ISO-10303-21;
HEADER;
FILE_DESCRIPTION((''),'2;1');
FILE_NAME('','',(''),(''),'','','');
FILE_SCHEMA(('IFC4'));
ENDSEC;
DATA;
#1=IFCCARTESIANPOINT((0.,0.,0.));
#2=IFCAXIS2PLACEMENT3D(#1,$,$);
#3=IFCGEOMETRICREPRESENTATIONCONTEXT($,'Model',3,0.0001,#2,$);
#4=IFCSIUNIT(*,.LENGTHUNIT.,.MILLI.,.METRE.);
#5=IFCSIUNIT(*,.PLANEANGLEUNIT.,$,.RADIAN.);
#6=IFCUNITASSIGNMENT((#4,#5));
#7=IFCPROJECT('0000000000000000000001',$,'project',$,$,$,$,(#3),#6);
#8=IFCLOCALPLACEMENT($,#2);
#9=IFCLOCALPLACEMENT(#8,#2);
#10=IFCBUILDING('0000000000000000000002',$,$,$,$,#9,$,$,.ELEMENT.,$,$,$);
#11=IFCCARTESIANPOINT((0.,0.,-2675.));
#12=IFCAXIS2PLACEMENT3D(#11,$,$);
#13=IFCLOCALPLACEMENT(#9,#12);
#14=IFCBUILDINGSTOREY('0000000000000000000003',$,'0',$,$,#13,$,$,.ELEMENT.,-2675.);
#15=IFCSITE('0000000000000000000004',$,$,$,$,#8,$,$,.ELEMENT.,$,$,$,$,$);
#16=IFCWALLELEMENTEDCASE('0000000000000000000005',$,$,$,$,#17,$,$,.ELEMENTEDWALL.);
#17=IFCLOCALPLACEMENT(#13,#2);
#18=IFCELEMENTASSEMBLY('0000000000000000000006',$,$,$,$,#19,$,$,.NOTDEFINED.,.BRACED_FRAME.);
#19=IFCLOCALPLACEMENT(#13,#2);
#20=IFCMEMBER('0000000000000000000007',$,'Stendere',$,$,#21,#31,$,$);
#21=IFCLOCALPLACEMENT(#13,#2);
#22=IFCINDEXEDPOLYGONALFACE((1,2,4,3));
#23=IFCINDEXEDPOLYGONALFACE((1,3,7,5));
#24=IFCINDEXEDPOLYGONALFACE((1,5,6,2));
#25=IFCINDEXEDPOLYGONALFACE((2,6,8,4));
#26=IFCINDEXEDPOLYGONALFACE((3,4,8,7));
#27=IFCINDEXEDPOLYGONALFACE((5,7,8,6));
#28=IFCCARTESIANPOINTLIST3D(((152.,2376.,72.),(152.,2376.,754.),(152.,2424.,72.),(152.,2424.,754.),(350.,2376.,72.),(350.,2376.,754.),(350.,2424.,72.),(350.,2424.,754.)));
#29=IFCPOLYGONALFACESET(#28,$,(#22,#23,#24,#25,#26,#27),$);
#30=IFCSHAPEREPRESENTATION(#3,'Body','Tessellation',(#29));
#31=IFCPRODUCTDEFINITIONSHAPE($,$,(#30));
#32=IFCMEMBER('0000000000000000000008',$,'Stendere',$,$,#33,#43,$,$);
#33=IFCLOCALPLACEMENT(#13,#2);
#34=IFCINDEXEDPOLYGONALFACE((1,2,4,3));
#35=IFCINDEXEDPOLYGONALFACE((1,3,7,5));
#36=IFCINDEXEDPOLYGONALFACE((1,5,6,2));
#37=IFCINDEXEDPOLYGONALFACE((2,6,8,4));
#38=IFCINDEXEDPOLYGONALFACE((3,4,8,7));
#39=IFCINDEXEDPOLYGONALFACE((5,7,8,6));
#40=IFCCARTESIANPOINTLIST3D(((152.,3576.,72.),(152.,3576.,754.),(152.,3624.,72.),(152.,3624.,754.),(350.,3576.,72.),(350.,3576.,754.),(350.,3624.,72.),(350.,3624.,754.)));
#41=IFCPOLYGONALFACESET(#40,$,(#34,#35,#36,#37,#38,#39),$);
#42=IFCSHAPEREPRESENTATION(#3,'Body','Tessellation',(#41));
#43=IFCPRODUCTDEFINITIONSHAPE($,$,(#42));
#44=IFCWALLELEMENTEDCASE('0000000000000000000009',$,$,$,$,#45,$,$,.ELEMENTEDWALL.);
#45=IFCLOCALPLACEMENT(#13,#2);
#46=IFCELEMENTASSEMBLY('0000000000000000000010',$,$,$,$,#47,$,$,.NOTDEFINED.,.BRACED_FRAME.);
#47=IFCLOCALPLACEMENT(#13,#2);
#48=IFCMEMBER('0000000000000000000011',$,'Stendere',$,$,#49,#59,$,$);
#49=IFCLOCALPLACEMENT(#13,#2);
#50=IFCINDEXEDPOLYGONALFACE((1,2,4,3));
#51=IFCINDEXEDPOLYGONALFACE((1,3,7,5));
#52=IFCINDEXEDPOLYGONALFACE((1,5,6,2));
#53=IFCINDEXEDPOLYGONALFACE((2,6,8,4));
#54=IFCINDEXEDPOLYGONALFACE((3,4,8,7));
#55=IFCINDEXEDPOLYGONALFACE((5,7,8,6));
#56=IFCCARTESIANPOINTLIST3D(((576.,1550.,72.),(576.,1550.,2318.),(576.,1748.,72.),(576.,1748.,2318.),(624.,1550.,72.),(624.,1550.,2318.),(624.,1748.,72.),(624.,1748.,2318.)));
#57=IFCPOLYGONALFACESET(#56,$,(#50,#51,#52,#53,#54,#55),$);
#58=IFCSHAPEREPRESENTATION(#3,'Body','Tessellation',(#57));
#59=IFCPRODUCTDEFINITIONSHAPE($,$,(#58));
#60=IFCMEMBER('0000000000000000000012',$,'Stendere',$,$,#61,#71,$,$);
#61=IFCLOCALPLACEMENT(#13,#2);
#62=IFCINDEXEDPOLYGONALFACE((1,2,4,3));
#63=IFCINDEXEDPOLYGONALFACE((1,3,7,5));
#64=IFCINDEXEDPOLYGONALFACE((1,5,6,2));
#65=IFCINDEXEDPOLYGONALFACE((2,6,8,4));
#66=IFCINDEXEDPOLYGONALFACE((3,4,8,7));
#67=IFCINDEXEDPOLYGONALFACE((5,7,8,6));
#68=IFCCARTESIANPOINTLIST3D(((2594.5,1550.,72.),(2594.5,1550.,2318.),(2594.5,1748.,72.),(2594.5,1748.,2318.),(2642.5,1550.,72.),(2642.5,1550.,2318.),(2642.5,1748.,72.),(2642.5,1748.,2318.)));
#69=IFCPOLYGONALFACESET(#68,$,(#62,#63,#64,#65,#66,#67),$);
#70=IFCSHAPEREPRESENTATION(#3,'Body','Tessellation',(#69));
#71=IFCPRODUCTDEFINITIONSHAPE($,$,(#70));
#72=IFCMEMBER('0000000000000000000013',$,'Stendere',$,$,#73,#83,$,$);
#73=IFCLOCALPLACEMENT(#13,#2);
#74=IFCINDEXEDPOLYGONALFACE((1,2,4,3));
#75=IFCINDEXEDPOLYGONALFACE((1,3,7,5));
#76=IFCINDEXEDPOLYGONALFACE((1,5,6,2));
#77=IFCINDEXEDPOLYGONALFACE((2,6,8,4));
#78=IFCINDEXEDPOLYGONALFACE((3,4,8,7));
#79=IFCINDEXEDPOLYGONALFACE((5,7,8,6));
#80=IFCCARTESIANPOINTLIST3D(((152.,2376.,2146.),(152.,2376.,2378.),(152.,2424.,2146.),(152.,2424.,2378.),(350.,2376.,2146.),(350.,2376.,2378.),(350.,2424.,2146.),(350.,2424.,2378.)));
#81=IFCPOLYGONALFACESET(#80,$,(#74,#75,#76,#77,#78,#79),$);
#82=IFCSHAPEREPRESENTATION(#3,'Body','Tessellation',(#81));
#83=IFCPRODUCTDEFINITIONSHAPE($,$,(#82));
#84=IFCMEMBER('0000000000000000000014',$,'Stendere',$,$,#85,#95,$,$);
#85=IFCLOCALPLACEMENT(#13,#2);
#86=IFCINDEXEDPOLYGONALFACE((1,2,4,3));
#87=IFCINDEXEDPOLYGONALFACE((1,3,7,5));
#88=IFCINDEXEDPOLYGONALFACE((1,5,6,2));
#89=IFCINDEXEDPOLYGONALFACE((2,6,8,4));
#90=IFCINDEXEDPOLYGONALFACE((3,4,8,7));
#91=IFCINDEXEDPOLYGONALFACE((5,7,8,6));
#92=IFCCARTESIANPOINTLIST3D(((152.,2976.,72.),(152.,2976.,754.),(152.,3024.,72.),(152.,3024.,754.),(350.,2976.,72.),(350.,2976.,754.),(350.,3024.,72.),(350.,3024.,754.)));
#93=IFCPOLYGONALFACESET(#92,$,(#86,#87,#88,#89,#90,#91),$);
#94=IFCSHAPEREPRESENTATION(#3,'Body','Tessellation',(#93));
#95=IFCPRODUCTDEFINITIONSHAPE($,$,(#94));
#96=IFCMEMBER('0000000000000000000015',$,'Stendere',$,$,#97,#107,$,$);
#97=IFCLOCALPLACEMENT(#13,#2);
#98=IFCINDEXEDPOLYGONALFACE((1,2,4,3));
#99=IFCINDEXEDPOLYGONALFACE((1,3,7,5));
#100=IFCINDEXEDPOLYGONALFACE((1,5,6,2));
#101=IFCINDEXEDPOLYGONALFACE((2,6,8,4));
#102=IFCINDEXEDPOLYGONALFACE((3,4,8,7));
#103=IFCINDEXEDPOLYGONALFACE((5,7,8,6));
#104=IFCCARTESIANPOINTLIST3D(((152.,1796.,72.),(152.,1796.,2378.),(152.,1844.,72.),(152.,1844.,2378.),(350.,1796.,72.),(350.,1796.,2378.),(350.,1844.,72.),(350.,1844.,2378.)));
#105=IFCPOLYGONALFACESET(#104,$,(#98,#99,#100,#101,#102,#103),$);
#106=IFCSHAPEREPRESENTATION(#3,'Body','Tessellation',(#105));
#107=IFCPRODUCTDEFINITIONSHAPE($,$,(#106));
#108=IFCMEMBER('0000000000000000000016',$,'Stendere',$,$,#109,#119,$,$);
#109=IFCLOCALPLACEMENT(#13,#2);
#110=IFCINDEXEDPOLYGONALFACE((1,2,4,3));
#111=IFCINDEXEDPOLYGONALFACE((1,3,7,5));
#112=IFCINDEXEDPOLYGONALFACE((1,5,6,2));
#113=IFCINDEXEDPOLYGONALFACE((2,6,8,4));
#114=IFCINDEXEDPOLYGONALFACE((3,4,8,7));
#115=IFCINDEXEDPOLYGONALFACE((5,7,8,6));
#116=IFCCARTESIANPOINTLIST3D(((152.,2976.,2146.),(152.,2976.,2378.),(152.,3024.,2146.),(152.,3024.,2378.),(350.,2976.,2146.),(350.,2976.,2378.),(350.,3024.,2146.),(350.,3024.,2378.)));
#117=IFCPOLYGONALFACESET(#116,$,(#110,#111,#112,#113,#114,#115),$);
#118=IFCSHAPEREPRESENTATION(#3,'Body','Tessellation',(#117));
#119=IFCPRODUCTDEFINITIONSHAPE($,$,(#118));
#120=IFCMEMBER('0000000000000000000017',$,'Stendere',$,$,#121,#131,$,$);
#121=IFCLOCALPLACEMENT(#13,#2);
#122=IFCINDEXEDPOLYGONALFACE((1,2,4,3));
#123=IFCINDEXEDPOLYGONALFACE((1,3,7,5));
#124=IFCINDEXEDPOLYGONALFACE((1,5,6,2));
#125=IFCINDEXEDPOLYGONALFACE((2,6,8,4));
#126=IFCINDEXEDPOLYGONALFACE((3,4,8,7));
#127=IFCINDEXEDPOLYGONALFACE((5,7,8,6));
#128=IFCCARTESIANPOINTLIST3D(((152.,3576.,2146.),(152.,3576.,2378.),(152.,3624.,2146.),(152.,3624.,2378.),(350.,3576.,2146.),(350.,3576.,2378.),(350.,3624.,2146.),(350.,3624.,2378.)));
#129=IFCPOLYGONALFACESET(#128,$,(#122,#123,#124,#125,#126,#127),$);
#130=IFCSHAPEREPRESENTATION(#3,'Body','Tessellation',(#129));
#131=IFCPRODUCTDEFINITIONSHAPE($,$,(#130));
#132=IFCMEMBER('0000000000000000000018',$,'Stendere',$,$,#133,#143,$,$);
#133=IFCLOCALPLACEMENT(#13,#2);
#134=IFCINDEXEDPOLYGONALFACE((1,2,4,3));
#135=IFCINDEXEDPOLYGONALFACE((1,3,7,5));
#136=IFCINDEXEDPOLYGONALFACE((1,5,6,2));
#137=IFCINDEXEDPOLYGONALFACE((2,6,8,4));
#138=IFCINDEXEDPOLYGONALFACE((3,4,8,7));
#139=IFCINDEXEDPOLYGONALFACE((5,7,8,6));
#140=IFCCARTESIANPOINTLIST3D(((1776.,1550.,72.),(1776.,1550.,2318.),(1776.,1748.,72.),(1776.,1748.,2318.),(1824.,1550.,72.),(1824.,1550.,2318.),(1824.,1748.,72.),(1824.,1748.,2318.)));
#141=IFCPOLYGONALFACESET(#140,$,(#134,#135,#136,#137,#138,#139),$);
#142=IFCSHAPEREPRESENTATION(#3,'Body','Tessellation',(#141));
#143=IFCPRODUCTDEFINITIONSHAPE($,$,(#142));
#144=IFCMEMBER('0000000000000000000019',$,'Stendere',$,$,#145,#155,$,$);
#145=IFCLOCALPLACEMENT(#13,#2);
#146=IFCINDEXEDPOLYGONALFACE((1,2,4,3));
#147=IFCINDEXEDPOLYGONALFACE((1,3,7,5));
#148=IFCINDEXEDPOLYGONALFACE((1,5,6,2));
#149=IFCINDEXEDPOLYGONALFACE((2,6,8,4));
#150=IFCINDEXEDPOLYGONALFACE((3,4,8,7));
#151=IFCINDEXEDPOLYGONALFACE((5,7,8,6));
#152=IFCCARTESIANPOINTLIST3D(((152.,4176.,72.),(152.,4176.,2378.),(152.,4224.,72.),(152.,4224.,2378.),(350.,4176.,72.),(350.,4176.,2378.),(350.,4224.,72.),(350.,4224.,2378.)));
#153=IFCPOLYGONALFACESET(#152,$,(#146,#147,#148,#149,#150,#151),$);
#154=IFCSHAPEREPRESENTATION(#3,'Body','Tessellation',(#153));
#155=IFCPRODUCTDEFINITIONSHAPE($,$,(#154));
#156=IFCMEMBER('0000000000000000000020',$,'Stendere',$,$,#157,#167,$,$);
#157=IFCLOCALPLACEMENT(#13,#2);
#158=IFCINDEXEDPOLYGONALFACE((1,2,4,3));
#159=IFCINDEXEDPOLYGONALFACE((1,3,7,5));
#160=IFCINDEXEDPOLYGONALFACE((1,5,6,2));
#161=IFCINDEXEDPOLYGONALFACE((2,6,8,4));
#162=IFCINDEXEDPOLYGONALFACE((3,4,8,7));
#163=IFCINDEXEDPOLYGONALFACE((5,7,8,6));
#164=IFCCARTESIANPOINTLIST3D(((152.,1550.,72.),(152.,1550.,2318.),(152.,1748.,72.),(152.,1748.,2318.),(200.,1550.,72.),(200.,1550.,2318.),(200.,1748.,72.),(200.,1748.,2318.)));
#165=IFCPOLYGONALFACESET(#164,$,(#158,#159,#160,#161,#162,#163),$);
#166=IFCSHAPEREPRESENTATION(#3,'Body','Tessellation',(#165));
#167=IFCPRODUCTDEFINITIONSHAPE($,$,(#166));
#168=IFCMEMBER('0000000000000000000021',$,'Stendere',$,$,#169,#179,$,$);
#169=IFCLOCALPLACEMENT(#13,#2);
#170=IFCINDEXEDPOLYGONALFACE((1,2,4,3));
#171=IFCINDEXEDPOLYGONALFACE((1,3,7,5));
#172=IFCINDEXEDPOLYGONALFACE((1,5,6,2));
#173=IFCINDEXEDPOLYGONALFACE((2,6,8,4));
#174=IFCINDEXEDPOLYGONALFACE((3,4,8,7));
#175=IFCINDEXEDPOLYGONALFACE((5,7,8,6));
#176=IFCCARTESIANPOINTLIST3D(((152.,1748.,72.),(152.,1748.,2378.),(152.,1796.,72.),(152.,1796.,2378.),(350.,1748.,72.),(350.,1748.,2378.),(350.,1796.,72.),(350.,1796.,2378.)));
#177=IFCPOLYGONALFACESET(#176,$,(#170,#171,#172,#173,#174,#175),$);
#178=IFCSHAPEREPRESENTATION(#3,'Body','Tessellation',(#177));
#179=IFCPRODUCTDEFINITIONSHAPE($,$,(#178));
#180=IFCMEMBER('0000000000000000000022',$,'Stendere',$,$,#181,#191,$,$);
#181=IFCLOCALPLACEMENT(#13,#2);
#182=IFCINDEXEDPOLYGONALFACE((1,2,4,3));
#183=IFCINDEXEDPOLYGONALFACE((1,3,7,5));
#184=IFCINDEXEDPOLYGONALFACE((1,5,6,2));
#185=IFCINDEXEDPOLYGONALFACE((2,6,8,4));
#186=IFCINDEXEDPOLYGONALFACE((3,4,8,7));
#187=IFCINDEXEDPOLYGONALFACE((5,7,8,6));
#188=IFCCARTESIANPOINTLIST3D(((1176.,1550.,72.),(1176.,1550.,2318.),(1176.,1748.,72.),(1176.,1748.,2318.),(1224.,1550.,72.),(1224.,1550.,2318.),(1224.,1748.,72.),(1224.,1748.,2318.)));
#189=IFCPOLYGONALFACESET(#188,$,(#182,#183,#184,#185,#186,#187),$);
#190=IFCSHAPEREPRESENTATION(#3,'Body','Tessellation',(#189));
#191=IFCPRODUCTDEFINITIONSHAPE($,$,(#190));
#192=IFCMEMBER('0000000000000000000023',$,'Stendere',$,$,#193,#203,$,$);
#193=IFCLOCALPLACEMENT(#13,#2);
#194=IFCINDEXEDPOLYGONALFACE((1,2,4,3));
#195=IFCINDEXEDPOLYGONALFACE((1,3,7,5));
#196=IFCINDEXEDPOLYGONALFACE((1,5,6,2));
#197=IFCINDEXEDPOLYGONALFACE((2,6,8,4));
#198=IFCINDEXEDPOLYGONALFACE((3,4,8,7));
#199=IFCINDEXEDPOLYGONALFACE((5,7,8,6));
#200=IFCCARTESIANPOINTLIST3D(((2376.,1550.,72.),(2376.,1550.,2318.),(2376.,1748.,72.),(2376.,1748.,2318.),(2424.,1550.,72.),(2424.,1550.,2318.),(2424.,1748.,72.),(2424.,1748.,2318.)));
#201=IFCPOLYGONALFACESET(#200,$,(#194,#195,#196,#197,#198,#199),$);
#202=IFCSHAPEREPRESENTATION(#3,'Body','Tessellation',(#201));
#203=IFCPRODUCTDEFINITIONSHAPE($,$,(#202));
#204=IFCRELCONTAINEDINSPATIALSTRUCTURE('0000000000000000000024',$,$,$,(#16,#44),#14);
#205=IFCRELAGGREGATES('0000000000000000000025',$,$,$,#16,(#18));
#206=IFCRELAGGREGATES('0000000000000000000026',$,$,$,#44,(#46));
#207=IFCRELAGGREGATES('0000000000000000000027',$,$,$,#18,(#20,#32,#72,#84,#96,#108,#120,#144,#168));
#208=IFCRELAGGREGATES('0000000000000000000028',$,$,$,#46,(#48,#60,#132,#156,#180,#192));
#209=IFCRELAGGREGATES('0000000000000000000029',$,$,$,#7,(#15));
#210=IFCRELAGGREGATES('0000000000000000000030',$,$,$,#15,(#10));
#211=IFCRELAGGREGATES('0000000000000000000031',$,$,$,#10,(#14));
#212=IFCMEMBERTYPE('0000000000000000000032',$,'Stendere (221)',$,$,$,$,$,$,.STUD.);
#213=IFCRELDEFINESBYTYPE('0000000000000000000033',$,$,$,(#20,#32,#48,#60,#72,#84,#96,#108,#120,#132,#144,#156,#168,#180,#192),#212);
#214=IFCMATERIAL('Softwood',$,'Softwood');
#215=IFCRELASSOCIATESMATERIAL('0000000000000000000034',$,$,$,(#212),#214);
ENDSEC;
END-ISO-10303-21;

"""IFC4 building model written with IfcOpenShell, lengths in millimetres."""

from ifc_helpers import new_model, si_unit, frame, origin, place, context, project, spatial, rectangle, extrude, material, material_profile, profile_set, type_object, element, aggregate, save


model = new_model("IFC4")

# Units and contexts
model_context = context("Model", 3, precision=0.0001, world=origin())
ifc_project = project(units=[si_unit("LENGTHUNIT", "METRE", prefix="MILLI"), si_unit("PLANEANGLEUNIT", "RADIAN")], contexts=[model_context])

# Site, building, storey
site_placement = place(None, origin())
site = spatial("IfcSite", under=ifc_project, at=site_placement, CompositionType="ELEMENT")
building_placement = place(site_placement, origin())
building = spatial("IfcBuilding", under=site, at=building_placement, CompositionType="ELEMENT")
storey_placement = place(building_placement, frame((0.0, 0.0, -2675.0)))
storey = spatial("IfcBuildingStorey", under=building, at=storey_placement, Name="0", CompositionType="ELEMENT", Elevation=-2675.0)

# Walls, element assemblies, members
wall_1_placement = place(storey_placement, frame((350.0, 6150.0, 0.0), z_axis=(-1.0, 0.0, 0.0), x_axis=(0.0, -1.0, 0.0)))
wall_1 = element("IfcWallElementedCase", 1, at=wall_1_placement, inside=storey, PredefinedType="ELEMENTEDWALL")
assembly_1_placement = place(wall_1_placement, origin())
assembly_1 = element("IfcElementAssembly", 2, at=assembly_1_placement, AssemblyPlace="NOTDEFINED", PredefinedType="BRACED_FRAME")
aggregate(wall_1, [assembly_1])
ifc_material_1 = material(Name="Softwood", Category="Softwood")
ifc_material_profile_1 = material_profile(ifc_material_1, rectangle(XDim=48.0, YDim=198.0), Name="Stendere (221)")
ifc_profile_set_1 = profile_set([ifc_material_profile_1])
member_type_1 = type_object("IfcMemberType", Name="Stendere (221)", PredefinedType="STUD", material=ifc_profile_set_1)
member_1_placement = place(assembly_1_placement, frame((3750.0, 72.0, 0.0), z_axis=(0.0, 1.0, 0.0), x_axis=(-1.0, 0.0, 0.0)))
member_1 = element("IfcMember", 3, at=member_1_placement, type_object=member_type_1, Name="Stendere", context=model_context, shape_type="SweptSolid", body=[
    extrude(rectangle(XDim=48.0, YDim=198.0), frame((0.0, 99.0, 0.0)), (0.0, 0.0, 1.0), 682.0),
])
member_2_placement = place(assembly_1_placement, frame((2550.0, 72.0, 0.0), z_axis=(0.0, 1.0, 0.0), x_axis=(-1.0, 0.0, 0.0)))
member_2 = element("IfcMember", 4, at=member_2_placement, type_object=member_type_1, Name="Stendere", context=model_context, shape_type="SweptSolid", body=[
    extrude(rectangle(XDim=48.0, YDim=198.0), frame((0.0, 99.0, 0.0)), (0.0, 0.0, 1.0), 682.0),
])
wall_2_placement = place(storey_placement, frame((350.0, 1748.0, 0.0), z_axis=(0.0, -1.0, 0.0)))
wall_2 = element("IfcWallElementedCase", 5, at=wall_2_placement, inside=storey, PredefinedType="ELEMENTEDWALL")
assembly_2_placement = place(wall_2_placement, origin())
assembly_2 = element("IfcElementAssembly", 6, at=assembly_2_placement, AssemblyPlace="NOTDEFINED", PredefinedType="BRACED_FRAME")
aggregate(wall_2, [assembly_2])
member_3_placement = place(assembly_2_placement, frame((250.0, 72.0, 0.0), z_axis=(0.0, 1.0, 0.0), x_axis=(-1.0, 0.0, 0.0)))
member_3 = element("IfcMember", 7, at=member_3_placement, type_object=member_type_1, Name="Stendere", context=model_context, shape_type="SweptSolid", body=[
    extrude(rectangle(XDim=48.0, YDim=198.0), frame((0.0, 99.0, 0.0)), (0.0, 0.0, 1.0), 2246.0),
])
member_4_placement = place(assembly_2_placement, frame((2268.5, 72.0, 0.0), z_axis=(0.0, 1.0, 0.0), x_axis=(-1.0, 0.0, 0.0)))
member_4 = element("IfcMember", 8, at=member_4_placement, type_object=member_type_1, Name="Stendere", context=model_context, shape_type="SweptSolid", body=[
    extrude(rectangle(XDim=48.0, YDim=198.0), frame((0.0, 99.0, 0.0)), (0.0, 0.0, 1.0), 2246.0),
])

# Members
member_5_placement = place(assembly_1_placement, frame((3750.0, 2146.0, 0.0), z_axis=(0.0, 1.0, 0.0), x_axis=(-1.0, 0.0, 0.0)))
member_5 = element("IfcMember", 9, at=member_5_placement, type_object=member_type_1, Name="Stendere", context=model_context, shape_type="SweptSolid", body=[
    extrude(rectangle(XDim=48.0, YDim=198.0), frame((0.0, 99.0, 0.0)), (0.0, 0.0, 1.0), 232.0),
])
member_6_placement = place(assembly_1_placement, frame((3150.0, 72.0, 0.0), z_axis=(0.0, 1.0, 0.0), x_axis=(-1.0, 0.0, 0.0)))
member_6 = element("IfcMember", 10, at=member_6_placement, type_object=member_type_1, Name="Stendere", context=model_context, shape_type="SweptSolid", body=[
    extrude(rectangle(XDim=48.0, YDim=198.0), frame((0.0, 99.0, 0.0)), (0.0, 0.0, 1.0), 682.0),
])
member_7_placement = place(assembly_1_placement, frame((4330.0, 72.0, 0.0), z_axis=(0.0, 1.0, 0.0), x_axis=(-1.0, 0.0, 0.0)))
member_7 = element("IfcMember", 11, at=member_7_placement, type_object=member_type_1, Name="Stendere", context=model_context, shape_type="SweptSolid", body=[
    extrude(rectangle(XDim=48.0, YDim=198.0), frame((0.0, 99.0, 0.0)), (0.0, 0.0, 1.0), 2306.0),
])
member_8_placement = place(assembly_1_placement, frame((3150.0, 2146.0, 0.0), z_axis=(0.0, 1.0, 0.0), x_axis=(-1.0, 0.0, 0.0)))
member_8 = element("IfcMember", 12, at=member_8_placement, type_object=member_type_1, Name="Stendere", context=model_context, shape_type="SweptSolid", body=[
    extrude(rectangle(XDim=48.0, YDim=198.0), frame((0.0, 99.0, 0.0)), (0.0, 0.0, 1.0), 232.0),
])
member_9_placement = place(assembly_1_placement, frame((2550.0, 2146.0, 0.0), z_axis=(0.0, 1.0, 0.0), x_axis=(-1.0, 0.0, 0.0)))
member_9 = element("IfcMember", 13, at=member_9_placement, type_object=member_type_1, Name="Stendere", context=model_context, shape_type="SweptSolid", body=[
    extrude(rectangle(XDim=48.0, YDim=198.0), frame((0.0, 99.0, 0.0)), (0.0, 0.0, 1.0), 232.0),
])
member_10_placement = place(assembly_2_placement, frame((1450.0, 72.0, 0.0), z_axis=(0.0, 1.0, 0.0), x_axis=(-1.0, 0.0, 0.0)))
member_10 = element("IfcMember", 14, at=member_10_placement, type_object=member_type_1, Name="Stendere", context=model_context, shape_type="SweptSolid", body=[
    extrude(rectangle(XDim=48.0, YDim=198.0), frame((0.0, 99.0, 0.0)), (0.0, 0.0, 1.0), 2246.0),
])
member_11_placement = place(assembly_1_placement, frame((1950.0, 72.0, 0.0), z_axis=(0.0, 1.0, 0.0), x_axis=(-1.0, 0.0, 0.0)))
member_11 = element("IfcMember", 15, at=member_11_placement, type_object=member_type_1, Name="Stendere", context=model_context, shape_type="SweptSolid", body=[
    extrude(rectangle(XDim=48.0, YDim=198.0), frame((0.0, 99.0, 0.0)), (0.0, 0.0, 1.0), 2306.0),
])
member_12_placement = place(assembly_2_placement, frame((-174.0, 72.0, 0.0), z_axis=(0.0, 1.0, 0.0), x_axis=(-1.0, 0.0, 0.0)))
member_12 = element("IfcMember", 16, at=member_12_placement, type_object=member_type_1, Name="Stendere", context=model_context, shape_type="SweptSolid", body=[
    extrude(rectangle(XDim=48.0, YDim=198.0), frame((0.0, 99.0, 0.0)), (0.0, 0.0, 1.0), 2246.0),
])
member_13_placement = place(assembly_1_placement, frame((4378.0, 72.0, 0.0), z_axis=(0.0, 1.0, 0.0), x_axis=(-1.0, 0.0, 0.0)))
member_13 = element("IfcMember", 17, at=member_13_placement, type_object=member_type_1, Name="Stendere", context=model_context, shape_type="SweptSolid", body=[
    extrude(rectangle(XDim=48.0, YDim=198.0), frame((0.0, 99.0, 0.0)), (0.0, 0.0, 1.0), 2306.0),
])
member_14_placement = place(assembly_2_placement, frame((850.0, 72.0, 0.0), z_axis=(0.0, 1.0, 0.0), x_axis=(-1.0, 0.0, 0.0)))
member_14 = element("IfcMember", 18, at=member_14_placement, type_object=member_type_1, Name="Stendere", context=model_context, shape_type="SweptSolid", body=[
    extrude(rectangle(XDim=48.0, YDim=198.0), frame((0.0, 99.0, 0.0)), (0.0, 0.0, 1.0), 2246.0),
])
member_15_placement = place(assembly_2_placement, frame((2050.0, 72.0, 0.0), z_axis=(0.0, 1.0, 0.0), x_axis=(-1.0, 0.0, 0.0)))
member_15 = element("IfcMember", 19, at=member_15_placement, type_object=member_type_1, Name="Stendere", context=model_context, shape_type="SweptSolid", body=[
    extrude(rectangle(XDim=48.0, YDim=198.0), frame((0.0, 99.0, 0.0)), (0.0, 0.0, 1.0), 2246.0),
])

aggregate(assembly_1, [member_1, member_2, member_5, member_6, member_7, member_8, member_9, member_11, member_13])

aggregate(assembly_2, [member_3, member_4, member_10, member_12, member_14, member_15])

save(model, "model.ifc")
